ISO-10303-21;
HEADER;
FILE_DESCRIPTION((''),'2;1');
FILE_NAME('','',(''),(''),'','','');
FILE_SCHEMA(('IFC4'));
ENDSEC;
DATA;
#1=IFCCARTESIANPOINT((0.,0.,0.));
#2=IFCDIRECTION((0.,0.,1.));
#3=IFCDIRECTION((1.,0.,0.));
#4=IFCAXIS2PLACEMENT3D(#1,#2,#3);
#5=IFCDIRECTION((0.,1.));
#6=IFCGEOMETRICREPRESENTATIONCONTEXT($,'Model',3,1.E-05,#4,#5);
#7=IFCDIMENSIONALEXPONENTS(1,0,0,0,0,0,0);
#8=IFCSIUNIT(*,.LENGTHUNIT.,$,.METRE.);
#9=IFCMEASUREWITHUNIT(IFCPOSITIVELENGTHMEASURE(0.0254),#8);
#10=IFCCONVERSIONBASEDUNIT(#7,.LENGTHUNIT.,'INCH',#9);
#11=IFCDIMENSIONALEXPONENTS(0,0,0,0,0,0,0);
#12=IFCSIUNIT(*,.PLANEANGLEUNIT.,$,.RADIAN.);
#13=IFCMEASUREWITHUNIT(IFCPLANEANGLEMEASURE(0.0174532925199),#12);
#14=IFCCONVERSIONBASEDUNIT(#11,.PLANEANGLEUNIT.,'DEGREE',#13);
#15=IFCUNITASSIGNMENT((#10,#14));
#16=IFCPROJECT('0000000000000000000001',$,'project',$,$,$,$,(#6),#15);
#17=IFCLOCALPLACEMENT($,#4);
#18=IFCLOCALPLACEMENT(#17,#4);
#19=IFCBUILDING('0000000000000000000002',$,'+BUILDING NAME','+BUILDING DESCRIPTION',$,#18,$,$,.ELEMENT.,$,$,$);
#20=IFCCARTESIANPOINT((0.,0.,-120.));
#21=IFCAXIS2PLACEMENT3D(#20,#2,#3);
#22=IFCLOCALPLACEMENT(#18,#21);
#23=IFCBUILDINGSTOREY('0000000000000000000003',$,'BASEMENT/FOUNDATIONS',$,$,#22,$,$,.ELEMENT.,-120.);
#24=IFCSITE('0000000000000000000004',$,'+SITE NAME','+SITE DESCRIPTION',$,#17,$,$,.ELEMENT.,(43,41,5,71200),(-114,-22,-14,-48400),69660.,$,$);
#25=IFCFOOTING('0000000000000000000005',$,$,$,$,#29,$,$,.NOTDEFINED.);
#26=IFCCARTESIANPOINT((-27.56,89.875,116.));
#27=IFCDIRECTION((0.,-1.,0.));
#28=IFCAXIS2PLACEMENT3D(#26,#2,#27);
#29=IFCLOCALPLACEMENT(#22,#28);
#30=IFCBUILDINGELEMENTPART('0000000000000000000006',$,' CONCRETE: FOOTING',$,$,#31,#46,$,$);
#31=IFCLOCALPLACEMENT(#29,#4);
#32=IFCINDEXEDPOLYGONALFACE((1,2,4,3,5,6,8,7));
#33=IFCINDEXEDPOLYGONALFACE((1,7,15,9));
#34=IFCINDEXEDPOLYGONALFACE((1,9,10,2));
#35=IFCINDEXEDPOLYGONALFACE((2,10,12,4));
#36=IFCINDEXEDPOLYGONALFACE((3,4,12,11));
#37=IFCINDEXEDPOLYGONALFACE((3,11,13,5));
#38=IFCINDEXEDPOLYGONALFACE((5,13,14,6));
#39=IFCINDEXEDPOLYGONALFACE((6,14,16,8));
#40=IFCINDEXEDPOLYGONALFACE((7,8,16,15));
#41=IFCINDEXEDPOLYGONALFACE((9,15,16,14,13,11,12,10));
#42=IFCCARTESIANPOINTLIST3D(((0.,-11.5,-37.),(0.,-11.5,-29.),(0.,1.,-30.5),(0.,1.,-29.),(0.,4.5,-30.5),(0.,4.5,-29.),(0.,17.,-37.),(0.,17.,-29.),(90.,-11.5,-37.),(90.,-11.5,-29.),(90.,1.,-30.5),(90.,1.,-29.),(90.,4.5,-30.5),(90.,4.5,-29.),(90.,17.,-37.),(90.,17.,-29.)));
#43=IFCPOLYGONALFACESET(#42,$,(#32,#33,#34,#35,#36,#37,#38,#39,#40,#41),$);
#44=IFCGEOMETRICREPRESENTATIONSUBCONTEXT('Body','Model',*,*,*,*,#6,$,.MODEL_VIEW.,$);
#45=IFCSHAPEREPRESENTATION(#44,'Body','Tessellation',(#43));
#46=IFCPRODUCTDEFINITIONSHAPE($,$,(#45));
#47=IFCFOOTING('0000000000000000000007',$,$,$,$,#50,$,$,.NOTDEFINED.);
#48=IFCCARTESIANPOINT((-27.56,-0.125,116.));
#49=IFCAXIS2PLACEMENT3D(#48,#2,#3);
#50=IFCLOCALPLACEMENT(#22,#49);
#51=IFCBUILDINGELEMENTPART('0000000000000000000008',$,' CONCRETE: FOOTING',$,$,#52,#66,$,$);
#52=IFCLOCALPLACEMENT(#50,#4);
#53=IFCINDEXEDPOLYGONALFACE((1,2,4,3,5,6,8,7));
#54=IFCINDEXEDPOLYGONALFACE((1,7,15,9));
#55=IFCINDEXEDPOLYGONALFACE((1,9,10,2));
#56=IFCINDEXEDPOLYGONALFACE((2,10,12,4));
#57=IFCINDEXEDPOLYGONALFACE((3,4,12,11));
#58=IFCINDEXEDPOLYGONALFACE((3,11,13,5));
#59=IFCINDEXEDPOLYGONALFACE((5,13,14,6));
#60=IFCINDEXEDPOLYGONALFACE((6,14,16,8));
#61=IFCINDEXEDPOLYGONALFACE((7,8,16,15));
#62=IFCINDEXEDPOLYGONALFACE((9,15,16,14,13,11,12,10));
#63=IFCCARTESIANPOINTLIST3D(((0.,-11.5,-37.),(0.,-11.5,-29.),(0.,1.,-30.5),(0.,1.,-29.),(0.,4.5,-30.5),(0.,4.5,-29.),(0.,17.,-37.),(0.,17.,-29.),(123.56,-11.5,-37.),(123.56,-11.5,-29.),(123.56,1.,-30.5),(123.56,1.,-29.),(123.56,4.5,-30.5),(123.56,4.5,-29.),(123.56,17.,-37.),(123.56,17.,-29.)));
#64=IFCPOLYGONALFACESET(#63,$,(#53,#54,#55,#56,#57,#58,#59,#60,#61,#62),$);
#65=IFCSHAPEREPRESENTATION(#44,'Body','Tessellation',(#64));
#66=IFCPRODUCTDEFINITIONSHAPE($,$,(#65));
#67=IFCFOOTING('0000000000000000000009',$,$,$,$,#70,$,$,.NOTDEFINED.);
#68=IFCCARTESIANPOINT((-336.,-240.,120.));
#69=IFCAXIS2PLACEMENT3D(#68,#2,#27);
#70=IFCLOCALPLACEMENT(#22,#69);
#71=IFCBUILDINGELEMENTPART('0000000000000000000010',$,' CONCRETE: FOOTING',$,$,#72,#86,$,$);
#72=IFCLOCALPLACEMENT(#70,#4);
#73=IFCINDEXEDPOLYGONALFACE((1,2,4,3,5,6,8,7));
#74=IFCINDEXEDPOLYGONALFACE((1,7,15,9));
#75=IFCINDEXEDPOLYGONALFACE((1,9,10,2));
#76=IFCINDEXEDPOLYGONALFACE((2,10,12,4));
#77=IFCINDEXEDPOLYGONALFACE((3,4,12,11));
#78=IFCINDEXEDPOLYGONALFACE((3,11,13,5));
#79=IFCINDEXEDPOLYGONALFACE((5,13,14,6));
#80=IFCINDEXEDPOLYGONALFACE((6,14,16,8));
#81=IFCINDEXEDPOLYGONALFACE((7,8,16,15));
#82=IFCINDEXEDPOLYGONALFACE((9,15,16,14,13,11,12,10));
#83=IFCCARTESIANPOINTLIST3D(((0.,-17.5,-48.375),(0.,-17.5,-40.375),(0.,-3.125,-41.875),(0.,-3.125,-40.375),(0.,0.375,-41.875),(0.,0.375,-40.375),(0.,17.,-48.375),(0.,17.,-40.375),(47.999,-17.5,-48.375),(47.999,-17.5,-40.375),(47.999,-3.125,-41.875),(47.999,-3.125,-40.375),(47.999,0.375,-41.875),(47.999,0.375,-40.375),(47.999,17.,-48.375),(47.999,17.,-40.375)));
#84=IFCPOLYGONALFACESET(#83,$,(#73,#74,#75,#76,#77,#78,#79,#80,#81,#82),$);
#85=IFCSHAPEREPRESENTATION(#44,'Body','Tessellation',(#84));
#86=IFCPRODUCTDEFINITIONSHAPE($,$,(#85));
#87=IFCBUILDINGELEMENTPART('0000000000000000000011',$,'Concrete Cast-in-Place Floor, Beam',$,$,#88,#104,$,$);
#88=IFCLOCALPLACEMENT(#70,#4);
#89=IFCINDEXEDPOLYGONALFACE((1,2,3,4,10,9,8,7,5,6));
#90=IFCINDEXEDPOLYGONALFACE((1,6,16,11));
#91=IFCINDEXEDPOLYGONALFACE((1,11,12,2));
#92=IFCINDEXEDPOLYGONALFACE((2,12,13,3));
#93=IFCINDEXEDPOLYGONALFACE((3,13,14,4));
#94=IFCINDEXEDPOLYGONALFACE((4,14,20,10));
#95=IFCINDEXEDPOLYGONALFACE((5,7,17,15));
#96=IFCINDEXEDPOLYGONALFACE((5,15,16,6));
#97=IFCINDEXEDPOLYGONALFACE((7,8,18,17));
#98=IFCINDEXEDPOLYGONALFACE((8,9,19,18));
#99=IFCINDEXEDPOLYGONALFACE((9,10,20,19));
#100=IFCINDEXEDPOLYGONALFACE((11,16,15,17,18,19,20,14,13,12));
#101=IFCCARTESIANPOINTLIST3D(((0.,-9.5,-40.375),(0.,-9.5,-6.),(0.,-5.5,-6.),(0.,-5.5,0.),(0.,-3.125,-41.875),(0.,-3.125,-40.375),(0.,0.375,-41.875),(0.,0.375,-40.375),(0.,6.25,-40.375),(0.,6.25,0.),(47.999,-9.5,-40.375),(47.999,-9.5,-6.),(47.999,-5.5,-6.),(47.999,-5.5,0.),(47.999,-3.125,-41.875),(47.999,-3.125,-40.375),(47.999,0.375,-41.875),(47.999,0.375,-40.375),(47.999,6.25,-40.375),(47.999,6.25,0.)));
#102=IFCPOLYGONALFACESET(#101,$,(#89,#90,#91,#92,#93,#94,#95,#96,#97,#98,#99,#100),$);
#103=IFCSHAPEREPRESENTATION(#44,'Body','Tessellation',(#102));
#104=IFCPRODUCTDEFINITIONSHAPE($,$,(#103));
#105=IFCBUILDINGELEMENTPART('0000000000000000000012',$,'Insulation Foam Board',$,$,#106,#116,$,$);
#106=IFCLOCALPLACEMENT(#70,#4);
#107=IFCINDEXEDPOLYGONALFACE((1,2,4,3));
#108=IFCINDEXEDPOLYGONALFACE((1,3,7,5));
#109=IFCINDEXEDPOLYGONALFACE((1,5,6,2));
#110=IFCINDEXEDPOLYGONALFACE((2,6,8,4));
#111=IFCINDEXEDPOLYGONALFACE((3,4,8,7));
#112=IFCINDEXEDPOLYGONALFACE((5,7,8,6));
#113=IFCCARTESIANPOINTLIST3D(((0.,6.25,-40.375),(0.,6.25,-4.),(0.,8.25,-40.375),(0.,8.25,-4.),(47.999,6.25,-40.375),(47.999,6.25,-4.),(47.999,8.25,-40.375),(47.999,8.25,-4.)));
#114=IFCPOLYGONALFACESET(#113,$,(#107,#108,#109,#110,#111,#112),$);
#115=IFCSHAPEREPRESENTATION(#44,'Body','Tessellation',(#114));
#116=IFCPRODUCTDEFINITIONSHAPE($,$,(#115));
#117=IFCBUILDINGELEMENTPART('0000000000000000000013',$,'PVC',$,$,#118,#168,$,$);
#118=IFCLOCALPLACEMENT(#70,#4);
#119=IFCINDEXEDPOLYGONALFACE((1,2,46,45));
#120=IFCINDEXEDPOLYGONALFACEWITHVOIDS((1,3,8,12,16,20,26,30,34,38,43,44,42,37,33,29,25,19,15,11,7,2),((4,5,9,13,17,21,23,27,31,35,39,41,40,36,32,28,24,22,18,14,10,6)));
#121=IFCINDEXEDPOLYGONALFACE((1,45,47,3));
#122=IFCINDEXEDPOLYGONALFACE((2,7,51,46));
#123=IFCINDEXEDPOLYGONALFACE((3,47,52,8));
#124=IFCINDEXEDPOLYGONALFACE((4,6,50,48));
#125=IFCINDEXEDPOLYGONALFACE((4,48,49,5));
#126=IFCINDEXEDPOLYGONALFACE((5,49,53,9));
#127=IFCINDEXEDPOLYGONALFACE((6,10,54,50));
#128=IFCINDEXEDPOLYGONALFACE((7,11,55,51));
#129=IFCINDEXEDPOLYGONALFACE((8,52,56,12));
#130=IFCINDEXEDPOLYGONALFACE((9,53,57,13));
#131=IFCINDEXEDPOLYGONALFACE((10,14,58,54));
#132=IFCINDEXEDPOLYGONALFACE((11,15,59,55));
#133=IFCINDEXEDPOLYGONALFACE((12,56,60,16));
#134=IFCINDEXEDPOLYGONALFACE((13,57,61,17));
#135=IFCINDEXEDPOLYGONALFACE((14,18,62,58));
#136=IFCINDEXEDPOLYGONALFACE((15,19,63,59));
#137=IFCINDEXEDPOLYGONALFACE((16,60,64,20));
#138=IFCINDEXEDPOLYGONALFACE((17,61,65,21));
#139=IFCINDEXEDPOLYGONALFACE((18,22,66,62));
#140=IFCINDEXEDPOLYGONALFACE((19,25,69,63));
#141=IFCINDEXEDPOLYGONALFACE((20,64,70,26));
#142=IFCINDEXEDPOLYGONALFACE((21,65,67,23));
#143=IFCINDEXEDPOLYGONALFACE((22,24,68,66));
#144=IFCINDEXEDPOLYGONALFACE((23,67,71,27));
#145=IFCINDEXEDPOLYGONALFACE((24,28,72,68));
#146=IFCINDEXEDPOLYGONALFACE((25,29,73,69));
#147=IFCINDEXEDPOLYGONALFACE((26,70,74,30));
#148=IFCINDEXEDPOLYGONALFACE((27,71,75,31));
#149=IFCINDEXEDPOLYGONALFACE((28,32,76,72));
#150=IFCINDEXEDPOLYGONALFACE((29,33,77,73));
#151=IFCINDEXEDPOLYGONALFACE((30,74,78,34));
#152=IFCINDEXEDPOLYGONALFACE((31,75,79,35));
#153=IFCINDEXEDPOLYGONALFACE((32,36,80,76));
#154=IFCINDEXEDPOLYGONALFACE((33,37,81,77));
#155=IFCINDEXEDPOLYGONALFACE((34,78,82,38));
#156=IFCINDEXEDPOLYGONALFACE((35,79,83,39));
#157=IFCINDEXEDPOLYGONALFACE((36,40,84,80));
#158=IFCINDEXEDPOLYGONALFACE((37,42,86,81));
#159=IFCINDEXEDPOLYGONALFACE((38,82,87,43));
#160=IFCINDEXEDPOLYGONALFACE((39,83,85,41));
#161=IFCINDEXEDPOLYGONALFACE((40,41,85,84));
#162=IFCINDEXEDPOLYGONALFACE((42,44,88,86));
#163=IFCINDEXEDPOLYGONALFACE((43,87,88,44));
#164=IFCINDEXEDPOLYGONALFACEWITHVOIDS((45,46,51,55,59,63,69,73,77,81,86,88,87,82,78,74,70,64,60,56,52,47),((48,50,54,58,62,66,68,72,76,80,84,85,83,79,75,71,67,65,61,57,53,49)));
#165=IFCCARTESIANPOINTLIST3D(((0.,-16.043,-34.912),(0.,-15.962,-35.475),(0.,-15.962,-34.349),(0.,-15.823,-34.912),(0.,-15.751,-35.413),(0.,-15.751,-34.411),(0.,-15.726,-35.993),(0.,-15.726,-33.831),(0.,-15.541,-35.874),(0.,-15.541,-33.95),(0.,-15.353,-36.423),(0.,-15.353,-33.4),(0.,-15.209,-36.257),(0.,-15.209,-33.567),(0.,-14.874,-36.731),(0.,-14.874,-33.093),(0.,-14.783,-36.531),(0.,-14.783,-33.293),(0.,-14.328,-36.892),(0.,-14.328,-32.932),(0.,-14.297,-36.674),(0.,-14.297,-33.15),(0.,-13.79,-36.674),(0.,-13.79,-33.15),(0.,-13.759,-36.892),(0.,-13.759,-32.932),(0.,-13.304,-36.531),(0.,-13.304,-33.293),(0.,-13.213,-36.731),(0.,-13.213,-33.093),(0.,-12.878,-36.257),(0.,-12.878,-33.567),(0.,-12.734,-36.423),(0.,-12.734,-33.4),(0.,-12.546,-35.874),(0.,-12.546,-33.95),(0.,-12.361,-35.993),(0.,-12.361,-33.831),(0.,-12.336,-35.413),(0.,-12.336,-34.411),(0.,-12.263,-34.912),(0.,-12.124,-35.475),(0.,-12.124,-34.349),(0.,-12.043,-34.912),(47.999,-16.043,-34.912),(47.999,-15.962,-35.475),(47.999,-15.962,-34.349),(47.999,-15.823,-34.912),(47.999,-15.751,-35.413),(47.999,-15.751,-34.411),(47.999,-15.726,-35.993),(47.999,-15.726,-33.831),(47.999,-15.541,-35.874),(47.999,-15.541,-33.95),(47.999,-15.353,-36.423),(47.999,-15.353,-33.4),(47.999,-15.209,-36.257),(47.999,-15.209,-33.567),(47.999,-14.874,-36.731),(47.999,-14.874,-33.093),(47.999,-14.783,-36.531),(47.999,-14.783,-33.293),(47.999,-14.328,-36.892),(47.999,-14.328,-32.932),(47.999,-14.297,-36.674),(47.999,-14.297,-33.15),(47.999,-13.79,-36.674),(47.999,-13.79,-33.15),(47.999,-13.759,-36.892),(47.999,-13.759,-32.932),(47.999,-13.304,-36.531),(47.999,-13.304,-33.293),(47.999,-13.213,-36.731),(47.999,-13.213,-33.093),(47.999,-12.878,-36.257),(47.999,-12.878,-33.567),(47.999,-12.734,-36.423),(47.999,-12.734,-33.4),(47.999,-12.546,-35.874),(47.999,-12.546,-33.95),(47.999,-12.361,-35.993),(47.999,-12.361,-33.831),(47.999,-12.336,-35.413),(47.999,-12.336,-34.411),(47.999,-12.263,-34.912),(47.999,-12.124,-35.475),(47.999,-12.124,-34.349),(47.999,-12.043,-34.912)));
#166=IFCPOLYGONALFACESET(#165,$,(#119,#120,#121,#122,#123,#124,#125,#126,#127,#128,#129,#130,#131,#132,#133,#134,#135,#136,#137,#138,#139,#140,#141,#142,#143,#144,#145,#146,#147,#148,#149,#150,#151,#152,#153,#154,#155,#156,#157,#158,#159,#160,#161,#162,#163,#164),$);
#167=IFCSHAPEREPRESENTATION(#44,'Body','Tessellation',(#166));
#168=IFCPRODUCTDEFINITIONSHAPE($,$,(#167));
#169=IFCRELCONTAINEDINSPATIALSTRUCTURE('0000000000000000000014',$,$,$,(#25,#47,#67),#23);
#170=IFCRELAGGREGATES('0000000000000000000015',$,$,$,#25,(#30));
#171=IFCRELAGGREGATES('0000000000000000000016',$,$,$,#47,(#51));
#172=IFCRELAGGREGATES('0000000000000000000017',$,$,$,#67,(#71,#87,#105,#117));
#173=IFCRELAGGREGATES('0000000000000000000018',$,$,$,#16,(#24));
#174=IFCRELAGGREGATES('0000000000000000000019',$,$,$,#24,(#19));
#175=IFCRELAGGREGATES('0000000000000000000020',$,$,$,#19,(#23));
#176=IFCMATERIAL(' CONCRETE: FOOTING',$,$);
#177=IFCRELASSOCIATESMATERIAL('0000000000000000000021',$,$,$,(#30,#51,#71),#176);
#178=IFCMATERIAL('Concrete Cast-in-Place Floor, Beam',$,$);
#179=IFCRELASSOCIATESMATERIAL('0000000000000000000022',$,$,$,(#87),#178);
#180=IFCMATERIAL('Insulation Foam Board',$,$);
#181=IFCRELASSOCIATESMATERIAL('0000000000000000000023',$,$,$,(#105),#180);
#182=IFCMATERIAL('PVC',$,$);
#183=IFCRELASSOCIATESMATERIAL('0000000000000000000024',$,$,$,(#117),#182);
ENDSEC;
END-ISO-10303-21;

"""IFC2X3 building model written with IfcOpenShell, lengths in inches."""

from ifc_helpers import new_model, entity, si_unit, converted_unit, point, direction, frame, frame_2d, origin_with_axes, place, context, subcontext, project, spatial, polyline, circle_curve, parameter, trimmed, segment, composite_curve, outline, extrude, material, element, aggregate, save


model = new_model("IFC2X3")

# Units and contexts
model_context = context("Model", 3, precision=1e-05, world=origin_with_axes(), true_north=direction((0.0, 1.0)))
body_context = subcontext(model_context, "Body", "Model", "MODEL_VIEW")
ifc_project = project(units=[converted_unit("LENGTHUNIT", "INCH", entity("IfcPositiveLengthMeasure", 0.0254), si_unit("LENGTHUNIT", "METRE"), dimensions=[1, 0, 0, 0, 0, 0, 0]), converted_unit("PLANEANGLEUNIT", "DEGREE", entity("IfcPlaneAngleMeasure", 0.0174532925199), si_unit("PLANEANGLEUNIT", "RADIAN"), dimensions=[0, 0, 0, 0, 0, 0, 0])], contexts=[model_context])

# Site, building, storey
site_placement = place(None, origin_with_axes())
site = spatial("IfcSite", under=ifc_project, at=site_placement, Name="+SITE NAME", Description="+SITE DESCRIPTION", CompositionType="ELEMENT", RefLatitude=(43, 41, 5, 71200), RefLongitude=(-114, -22, -14, -48400), RefElevation=69660.0)
building_placement = place(site_placement, origin_with_axes())
building = spatial("IfcBuilding", under=site, at=building_placement, Name="+BUILDING NAME", Description="+BUILDING DESCRIPTION", CompositionType="ELEMENT")
storey_placement = place(building_placement, frame((0.0, 0.0, -120.0), z_axis=(0.0, 0.0, 1.0), x_axis=(1.0, 0.0, 0.0)))
storey = spatial("IfcBuildingStorey", under=building, at=storey_placement, Name="BASEMENT/FOUNDATIONS", CompositionType="ELEMENT", Elevation=-120.0)

# Footings, building element parts
footing_1_placement = place(storey_placement, frame((-27.56, 89.875, 116.0), z_axis=(0.0, 0.0, 1.0), x_axis=(0.0, -1.0, 0.0)))
footing_1 = element("IfcFooting", 1, at=footing_1_placement, inside=storey, PredefinedType="NOTDEFINED")
ifc_material_1 = material(Name=" CONCRETE: FOOTING")
building_element_part_1_placement = place(footing_1_placement, origin_with_axes())
building_element_part_1 = element("IfcBuildingElementPart", 2, at=building_element_part_1_placement, material=ifc_material_1, Name=" CONCRETE: FOOTING", context=body_context, shape_type="SweptSolid", body=[
    extrude(outline(polyline([(-14.25, -37.0), (14.25, -37.0), (14.25, -29.0), (1.75, -29.0), (1.75, -30.5), (-1.75, -30.5), (-1.75, -29.0), (-14.25, -29.0), (-14.25, -37.0)])), frame((0.0, 2.75, 0.0), z_axis=(1.0, 0.0, 0.0), x_axis=(0.0, 1.0, 0.0)), (0.0, 0.0, 1.0), 90.0),
])
ifc_material_2 = material(Name="Concrete Cast-in-Place Floor, Beam")
aggregate(footing_1, [building_element_part_1])
footing_2_placement = place(storey_placement, frame((-27.56, -0.125, 116.0), z_axis=(0.0, 0.0, 1.0), x_axis=(1.0, 0.0, 0.0)))
footing_2 = element("IfcFooting", 3, at=footing_2_placement, inside=storey, PredefinedType="NOTDEFINED")
building_element_part_2_placement = place(footing_2_placement, origin_with_axes())
building_element_part_2 = element("IfcBuildingElementPart", 4, at=building_element_part_2_placement, material=ifc_material_1, Name=" CONCRETE: FOOTING", context=body_context, shape_type="SweptSolid", body=[
    extrude(outline(polyline([(-14.25, -37.0), (14.25, -37.0), (14.25, -29.0), (1.75, -29.0), (1.75, -30.5), (-1.75, -30.5), (-1.75, -29.0), (-14.25, -29.0), (-14.25, -37.0)])), frame((0.0, 2.75, 0.0), z_axis=(1.0, 0.0, 0.0), x_axis=(0.0, 1.0, 0.0)), (0.0, 0.0, 1.0), 123.56),
])
aggregate(footing_2, [building_element_part_2])
footing_3_placement = place(storey_placement, frame((-336.0, -240.0, 120.0), z_axis=(0.0, 0.0, 1.0), x_axis=(0.0, -1.0, 0.0)))
footing_3 = element("IfcFooting", 5, at=footing_3_placement, inside=storey, PredefinedType="NOTDEFINED")
building_element_part_3_placement = place(footing_3_placement, origin_with_axes())
building_element_part_3 = element("IfcBuildingElementPart", 6, at=building_element_part_3_placement, material=ifc_material_1, Name=" CONCRETE: FOOTING", context=body_context, shape_type="SweptSolid", body=[
    extrude(outline(polyline([(-17.0, -48.375), (17.5, -48.375), (17.5, -40.375), (3.125, -40.375), (3.125, -41.875), (-0.375, -41.875), (-0.375, -40.375), (-17.0, -40.375), (-17.0, -48.375)])), frame((0.0, 0.0, 0.0), z_axis=(-1.0, 0.0, 0.0), x_axis=(0.0, -1.0, 0.0)), (0.0, 0.0, -1.0), 47.999),
])
building_element_part_4_placement = place(footing_3_placement, origin_with_axes())
building_element_part_4 = element("IfcBuildingElementPart", 7, at=building_element_part_4_placement, material=ifc_material_2, Name="Concrete Cast-in-Place Floor, Beam", context=body_context, shape_type="SweptSolid", body=[
    extrude(outline(polyline([(-6.25, 0.0), (-6.25, -40.375), (-0.375, -40.375), (-0.375, -41.875), (3.125, -41.875), (3.125, -40.375), (9.5, -40.375), (9.5, -6.0), (5.5, -6.0), (5.5, 0.0), (-6.25, 0.0)])), frame((0.0, 0.0, 0.0), z_axis=(-1.0, 0.0, 0.0), x_axis=(0.0, -1.0, 0.0)), (0.0, 0.0, -1.0), 47.999),
])
ifc_material_3 = material(Name="Insulation Foam Board")
building_element_part_5_placement = place(footing_3_placement, origin_with_axes())
building_element_part_5 = element("IfcBuildingElementPart", 8, at=building_element_part_5_placement, material=ifc_material_3, Name="Insulation Foam Board", context=body_context, shape_type="SweptSolid", body=[
    extrude(outline(polyline([(-6.25, -4.0), (-8.25, -4.0), (-8.25, -40.375), (-6.25, -40.375), (-6.25, -4.0)])), frame((0.0, 0.0, 0.0), z_axis=(-1.0, 0.0, 0.0), x_axis=(0.0, -1.0, 0.0)), (0.0, 0.0, -1.0), 47.999),
])
ifc_material_4 = material(Name="PVC")
building_element_part_6_placement = place(footing_3_placement, origin_with_axes())
building_element_part_6 = element("IfcBuildingElementPart", 9, at=building_element_part_6_placement, material=ifc_material_4, Name="PVC", context=body_context, shape_type="SweptSolid", body=[
    extrude(outline(composite_curve([segment(trimmed(circle_curve(frame_2d((14.043, -34.912), x_axis=(1.0, 0.0)), 2.0), [point((16.043, -34.912)), parameter(0.0)], [point((12.043, -34.912)), parameter(180.0)], True, "CARTESIAN"), True, "CONTINUOUS"), segment(trimmed(circle_curve(frame_2d((14.043, -34.912), x_axis=(-1.0, 0.0)), 2.0), [point((12.043, -34.912)), parameter(0.0)], [point((16.043, -34.912)), parameter(180.0)], True, "CARTESIAN"), True, "CONTINUOUS")], self_intersect=False), holes=[composite_curve([segment(trimmed(circle_curve(frame_2d((14.043, -34.912), x_axis=(-1.0, 0.0)), 1.78), [point((15.823, -34.912)), parameter(180.0)], [point((12.263, -34.912)), parameter(0.0)], False, "CARTESIAN"), True, "CONTINUOUS"), segment(trimmed(circle_curve(frame_2d((14.043, -34.912), x_axis=(1.0, 0.0)), 1.78), [point((12.263, -34.912)), parameter(180.0)], [point((15.823, -34.912)), parameter(0.0)], False, "CARTESIAN"), True, "CONTINUOUS")], self_intersect=False)]), frame((0.0, 0.0, 0.0), z_axis=(-1.0, 0.0, 0.0), x_axis=(0.0, -1.0, 0.0)), (0.0, 0.0, -1.0), 47.999),
])
aggregate(footing_3, [building_element_part_3, building_element_part_4, building_element_part_5, building_element_part_6])

save(model, "model.ifc")
